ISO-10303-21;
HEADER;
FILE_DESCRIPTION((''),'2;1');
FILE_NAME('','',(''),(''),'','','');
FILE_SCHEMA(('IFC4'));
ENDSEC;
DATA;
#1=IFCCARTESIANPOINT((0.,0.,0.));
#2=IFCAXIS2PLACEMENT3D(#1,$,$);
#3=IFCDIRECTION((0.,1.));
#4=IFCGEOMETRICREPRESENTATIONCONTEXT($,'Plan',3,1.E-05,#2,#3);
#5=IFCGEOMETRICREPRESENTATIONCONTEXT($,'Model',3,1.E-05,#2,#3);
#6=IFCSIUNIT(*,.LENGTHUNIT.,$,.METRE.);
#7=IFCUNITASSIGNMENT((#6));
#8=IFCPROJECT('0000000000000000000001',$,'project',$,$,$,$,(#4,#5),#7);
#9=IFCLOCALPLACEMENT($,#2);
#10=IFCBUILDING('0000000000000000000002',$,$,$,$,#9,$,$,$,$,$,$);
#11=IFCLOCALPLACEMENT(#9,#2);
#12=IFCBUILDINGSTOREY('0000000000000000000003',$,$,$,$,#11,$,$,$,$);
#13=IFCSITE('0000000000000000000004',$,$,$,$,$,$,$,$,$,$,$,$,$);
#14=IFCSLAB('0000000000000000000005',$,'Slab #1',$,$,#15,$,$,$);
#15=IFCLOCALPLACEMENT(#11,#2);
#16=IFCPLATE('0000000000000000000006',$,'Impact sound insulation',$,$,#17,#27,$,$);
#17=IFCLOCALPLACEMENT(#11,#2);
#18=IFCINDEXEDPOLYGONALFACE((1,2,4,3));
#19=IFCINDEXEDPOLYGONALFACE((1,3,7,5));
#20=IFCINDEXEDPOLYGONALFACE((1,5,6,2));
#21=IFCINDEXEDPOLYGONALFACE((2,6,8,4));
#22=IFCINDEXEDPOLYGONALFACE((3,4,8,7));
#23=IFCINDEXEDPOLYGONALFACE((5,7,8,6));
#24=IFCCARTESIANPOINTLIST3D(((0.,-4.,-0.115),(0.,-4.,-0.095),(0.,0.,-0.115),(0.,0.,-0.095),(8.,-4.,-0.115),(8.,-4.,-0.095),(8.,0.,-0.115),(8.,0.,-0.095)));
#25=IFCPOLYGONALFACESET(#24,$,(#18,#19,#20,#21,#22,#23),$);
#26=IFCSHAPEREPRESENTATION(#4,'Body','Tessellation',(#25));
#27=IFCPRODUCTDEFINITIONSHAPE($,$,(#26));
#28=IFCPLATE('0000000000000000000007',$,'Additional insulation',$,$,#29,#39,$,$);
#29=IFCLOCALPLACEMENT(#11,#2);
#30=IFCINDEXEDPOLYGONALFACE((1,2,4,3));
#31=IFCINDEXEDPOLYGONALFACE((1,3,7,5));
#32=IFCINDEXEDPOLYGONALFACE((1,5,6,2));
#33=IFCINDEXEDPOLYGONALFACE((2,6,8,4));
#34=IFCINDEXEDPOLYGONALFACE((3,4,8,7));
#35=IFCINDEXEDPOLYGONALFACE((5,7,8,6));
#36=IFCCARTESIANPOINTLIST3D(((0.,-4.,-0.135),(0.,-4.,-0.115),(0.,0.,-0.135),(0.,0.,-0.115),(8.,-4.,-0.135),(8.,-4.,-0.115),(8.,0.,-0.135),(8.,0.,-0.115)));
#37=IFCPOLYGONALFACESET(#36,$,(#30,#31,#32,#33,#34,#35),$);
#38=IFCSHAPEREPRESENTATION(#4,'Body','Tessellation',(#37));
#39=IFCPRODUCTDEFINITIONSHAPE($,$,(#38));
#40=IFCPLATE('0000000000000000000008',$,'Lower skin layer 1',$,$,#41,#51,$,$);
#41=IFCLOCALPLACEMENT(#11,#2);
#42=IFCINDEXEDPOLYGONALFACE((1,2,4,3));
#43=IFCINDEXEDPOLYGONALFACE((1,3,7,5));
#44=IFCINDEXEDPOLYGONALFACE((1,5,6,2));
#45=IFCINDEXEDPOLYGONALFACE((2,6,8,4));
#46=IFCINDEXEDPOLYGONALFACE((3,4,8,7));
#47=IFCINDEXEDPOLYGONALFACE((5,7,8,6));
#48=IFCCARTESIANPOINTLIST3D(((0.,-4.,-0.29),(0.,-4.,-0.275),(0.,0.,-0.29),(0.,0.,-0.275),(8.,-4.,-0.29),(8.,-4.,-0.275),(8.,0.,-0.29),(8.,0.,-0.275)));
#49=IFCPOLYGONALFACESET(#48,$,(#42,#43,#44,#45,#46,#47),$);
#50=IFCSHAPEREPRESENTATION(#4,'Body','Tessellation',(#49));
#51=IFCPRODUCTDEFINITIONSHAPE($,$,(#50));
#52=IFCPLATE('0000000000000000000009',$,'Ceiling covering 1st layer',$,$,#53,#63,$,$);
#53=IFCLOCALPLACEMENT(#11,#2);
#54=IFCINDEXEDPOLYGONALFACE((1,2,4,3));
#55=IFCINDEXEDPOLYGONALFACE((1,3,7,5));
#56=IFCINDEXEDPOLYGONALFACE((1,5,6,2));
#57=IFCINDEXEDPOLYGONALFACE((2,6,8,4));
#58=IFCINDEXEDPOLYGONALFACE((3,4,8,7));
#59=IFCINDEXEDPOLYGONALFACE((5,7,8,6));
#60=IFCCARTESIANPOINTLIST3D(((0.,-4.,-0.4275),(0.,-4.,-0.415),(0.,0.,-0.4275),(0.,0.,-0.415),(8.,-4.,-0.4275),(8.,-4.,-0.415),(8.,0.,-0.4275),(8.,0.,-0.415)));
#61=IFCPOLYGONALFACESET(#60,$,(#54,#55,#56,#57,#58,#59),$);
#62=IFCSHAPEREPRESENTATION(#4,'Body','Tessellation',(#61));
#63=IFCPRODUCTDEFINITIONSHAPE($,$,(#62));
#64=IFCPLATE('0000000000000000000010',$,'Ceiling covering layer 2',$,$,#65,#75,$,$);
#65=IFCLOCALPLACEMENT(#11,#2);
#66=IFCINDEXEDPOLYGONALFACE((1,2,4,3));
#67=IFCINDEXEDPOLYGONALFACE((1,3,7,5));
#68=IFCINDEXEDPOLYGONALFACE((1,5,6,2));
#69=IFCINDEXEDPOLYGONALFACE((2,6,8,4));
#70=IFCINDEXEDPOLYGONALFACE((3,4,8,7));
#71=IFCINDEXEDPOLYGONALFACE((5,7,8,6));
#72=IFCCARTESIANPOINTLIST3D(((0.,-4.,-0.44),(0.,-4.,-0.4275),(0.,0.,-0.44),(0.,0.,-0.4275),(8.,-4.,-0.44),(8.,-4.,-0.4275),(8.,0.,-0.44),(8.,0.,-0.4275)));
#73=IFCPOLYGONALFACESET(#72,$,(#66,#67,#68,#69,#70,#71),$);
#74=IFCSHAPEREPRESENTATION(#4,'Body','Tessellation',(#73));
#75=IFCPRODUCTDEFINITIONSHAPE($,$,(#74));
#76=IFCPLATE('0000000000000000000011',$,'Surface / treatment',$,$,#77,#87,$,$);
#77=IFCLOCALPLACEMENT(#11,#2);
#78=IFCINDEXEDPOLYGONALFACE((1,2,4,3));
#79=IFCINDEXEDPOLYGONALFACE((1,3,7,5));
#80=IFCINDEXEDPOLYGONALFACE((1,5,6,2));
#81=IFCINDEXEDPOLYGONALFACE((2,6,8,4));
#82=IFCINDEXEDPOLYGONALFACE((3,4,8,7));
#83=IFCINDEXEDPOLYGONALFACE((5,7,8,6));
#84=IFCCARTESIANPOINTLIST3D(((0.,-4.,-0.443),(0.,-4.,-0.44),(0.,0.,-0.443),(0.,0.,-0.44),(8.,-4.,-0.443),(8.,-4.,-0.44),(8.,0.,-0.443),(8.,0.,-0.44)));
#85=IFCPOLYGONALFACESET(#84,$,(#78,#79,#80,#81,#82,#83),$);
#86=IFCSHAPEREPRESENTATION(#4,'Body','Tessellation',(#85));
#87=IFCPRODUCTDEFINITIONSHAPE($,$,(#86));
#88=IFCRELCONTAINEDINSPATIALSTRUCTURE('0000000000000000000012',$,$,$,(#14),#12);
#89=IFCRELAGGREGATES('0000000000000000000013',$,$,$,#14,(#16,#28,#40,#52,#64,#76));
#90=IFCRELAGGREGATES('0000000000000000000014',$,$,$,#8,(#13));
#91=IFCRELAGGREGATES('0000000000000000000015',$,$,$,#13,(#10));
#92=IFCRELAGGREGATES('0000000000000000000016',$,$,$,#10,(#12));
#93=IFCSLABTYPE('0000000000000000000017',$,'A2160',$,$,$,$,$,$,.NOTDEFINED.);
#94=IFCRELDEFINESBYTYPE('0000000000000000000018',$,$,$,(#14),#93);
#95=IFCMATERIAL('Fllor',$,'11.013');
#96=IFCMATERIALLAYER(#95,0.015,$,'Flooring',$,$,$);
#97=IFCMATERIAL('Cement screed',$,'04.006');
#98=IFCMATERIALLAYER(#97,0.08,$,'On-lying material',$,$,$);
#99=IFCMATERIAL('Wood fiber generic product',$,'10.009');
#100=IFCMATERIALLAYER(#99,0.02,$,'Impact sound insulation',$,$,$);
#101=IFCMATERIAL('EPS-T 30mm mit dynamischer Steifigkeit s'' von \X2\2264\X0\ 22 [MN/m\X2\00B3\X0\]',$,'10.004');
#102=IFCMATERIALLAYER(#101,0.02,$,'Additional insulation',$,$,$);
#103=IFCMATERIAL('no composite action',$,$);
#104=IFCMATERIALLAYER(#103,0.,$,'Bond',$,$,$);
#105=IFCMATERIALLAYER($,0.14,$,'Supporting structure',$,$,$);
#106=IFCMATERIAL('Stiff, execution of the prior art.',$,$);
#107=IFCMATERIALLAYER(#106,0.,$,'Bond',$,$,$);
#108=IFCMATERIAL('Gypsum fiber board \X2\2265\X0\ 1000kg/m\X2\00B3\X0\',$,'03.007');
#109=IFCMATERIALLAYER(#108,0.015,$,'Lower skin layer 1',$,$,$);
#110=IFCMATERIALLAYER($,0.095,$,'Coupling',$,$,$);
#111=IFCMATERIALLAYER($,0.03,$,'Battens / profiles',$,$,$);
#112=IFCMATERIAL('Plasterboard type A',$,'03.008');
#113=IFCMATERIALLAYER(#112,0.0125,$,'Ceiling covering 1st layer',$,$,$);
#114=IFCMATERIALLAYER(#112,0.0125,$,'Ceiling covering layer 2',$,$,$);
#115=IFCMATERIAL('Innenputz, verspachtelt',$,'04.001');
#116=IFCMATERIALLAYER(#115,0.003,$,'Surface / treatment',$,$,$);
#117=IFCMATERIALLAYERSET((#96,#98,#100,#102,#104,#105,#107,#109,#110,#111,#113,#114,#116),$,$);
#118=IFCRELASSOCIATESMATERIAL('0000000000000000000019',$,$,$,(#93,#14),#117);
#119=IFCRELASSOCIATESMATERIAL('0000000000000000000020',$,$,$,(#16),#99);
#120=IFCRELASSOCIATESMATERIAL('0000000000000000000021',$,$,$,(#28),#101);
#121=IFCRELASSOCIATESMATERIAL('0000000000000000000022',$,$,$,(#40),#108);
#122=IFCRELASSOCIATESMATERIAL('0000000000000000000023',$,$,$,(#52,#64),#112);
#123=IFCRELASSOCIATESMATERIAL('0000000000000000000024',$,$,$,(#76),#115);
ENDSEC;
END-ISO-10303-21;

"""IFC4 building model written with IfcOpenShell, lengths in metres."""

from ifc_helpers import new_model, si_unit, direction, frame, frame_2d, origin, place, context, project, spatial, rectangle, extrude, material, layer, layer_set, type_object, element, aggregate, save


model = new_model("IFC4")

# Units and contexts
plan_context = context("Plan", 3, precision=1e-05, world=origin(), true_north=direction((0.0, 1.0)))
model_context = context("Model", 3, precision=1e-05, world=origin(), true_north=direction((0.0, 1.0)))
ifc_project = project(units=[si_unit("LENGTHUNIT", "METRE")], contexts=[plan_context, model_context])

# Site, building, storey
site = spatial("IfcSite", under=ifc_project)
building_placement = place(None, origin())
building = spatial("IfcBuilding", under=site, at=building_placement)
storey_placement = place(building_placement, origin())
storey = spatial("IfcBuildingStorey", under=building, at=storey_placement)

# Slab, plates
ifc_material_1 = material(Name="Fllor", Category="11.013")
ifc_layer_1 = layer(ifc_material_1, 0.015, Name="Flooring")
ifc_material_2 = material(Name="Cement screed", Category="04.006")
ifc_layer_2 = layer(ifc_material_2, 0.08, Name="On-lying material")
ifc_material_3 = material(Name="Wood fiber generic product", Category="10.009")
ifc_layer_3 = layer(ifc_material_3, 0.02, Name="Impact sound insulation")
ifc_material_4 = material(Name="EPS-T 30mm mit dynamischer Steifigkeit s' von ≤ 22 [MN/m³]", Category="10.004")
ifc_layer_4 = layer(ifc_material_4, 0.02, Name="Additional insulation")
ifc_material_5 = material(Name="no composite action")
ifc_layer_5 = layer(ifc_material_5, 0.0, Name="Bond")
ifc_layer_6 = layer(None, 0.14, Name="Supporting structure")
ifc_material_6 = material(Name="Stiff, execution of the prior art.")
ifc_layer_7 = layer(ifc_material_6, 0.0, Name="Bond")
ifc_material_7 = material(Name="Gypsum fiber board ≥ 1000kg/m³", Category="03.007")
ifc_layer_8 = layer(ifc_material_7, 0.015, Name="Lower skin layer 1")
ifc_layer_9 = layer(None, 0.095, Name="Coupling")
ifc_layer_10 = layer(None, 0.03, Name="Battens / profiles")
ifc_material_8 = material(Name="Plasterboard type A", Category="03.008")
ifc_layer_11 = layer(ifc_material_8, 0.0125, Name="Ceiling covering 1st layer")
ifc_layer_12 = layer(ifc_material_8, 0.0125, Name="Ceiling covering layer 2")
ifc_material_9 = material(Name="Innenputz, verspachtelt", Category="04.001")
ifc_layer_13 = layer(ifc_material_9, 0.003, Name="Surface / treatment")
ifc_layer_set = layer_set([ifc_layer_1, ifc_layer_2, ifc_layer_3, ifc_layer_4, ifc_layer_5, ifc_layer_6, ifc_layer_7, ifc_layer_8, ifc_layer_9, ifc_layer_10, ifc_layer_11, ifc_layer_12, ifc_layer_13])
slab_type = type_object("IfcSlabType", Name="A2160", PredefinedType="NOTDEFINED", material=ifc_layer_set)
slab_placement = place(None, frame((0.0, 0.0, 0.0), z_axis=(0.0, 0.0, -1.0), x_axis=(1.0, 0.0, 0.0)))
slab = element("IfcSlab", 1, at=slab_placement, inside=storey, type_object=slab_type, material=ifc_layer_set, Name="Slab #1")
plate_1_placement = place(slab_placement, origin())
plate_1 = element("IfcPlate", 2, at=plate_1_placement, material=ifc_material_3, Name="Impact sound insulation", context=plan_context, shape_type="SweptSolid", body=[
    extrude(rectangle(XDim=8.0, YDim=4.0, at=frame_2d((4.0, 2.0), x_axis=(1.0, 0.0))), frame((0.0, 0.0, 0.095), z_axis=(0.0, 0.0, 1.0), x_axis=(1.0, 0.0, 0.0)), (0.0, 0.0, 1.0), 0.02),
])
plate_2_placement = place(slab_placement, origin())
plate_2 = element("IfcPlate", 3, at=plate_2_placement, material=ifc_material_4, Name="Additional insulation", context=plan_context, shape_type="SweptSolid", body=[
    extrude(rectangle(XDim=8.0, YDim=4.0, at=frame_2d((4.0, 2.0), x_axis=(1.0, 0.0))), frame((0.0, 0.0, 0.115), z_axis=(0.0, 0.0, 1.0), x_axis=(1.0, 0.0, 0.0)), (0.0, 0.0, 1.0), 0.02),
])
plate_3_placement = place(slab_placement, origin())
plate_3 = element("IfcPlate", 4, at=plate_3_placement, material=ifc_material_7, Name="Lower skin layer 1", context=plan_context, shape_type="SweptSolid", body=[
    extrude(rectangle(XDim=8.0, YDim=4.0, at=frame_2d((4.0, 2.0), x_axis=(1.0, 0.0))), frame((0.0, 0.0, 0.275), z_axis=(0.0, 0.0, 1.0), x_axis=(1.0, 0.0, 0.0)), (0.0, 0.0, 1.0), 0.015),
])
plate_4_placement = place(slab_placement, origin())
plate_4 = element("IfcPlate", 5, at=plate_4_placement, material=ifc_material_8, Name="Ceiling covering 1st layer", context=plan_context, shape_type="SweptSolid", body=[
    extrude(rectangle(XDim=8.0, YDim=4.0, at=frame_2d((4.0, 2.0), x_axis=(1.0, 0.0))), frame((0.0, 0.0, 0.415), z_axis=(0.0, 0.0, 1.0), x_axis=(1.0, 0.0, 0.0)), (0.0, 0.0, 1.0), 0.0125),
])
plate_5_placement = place(slab_placement, origin())
plate_5 = element("IfcPlate", 6, at=plate_5_placement, material=ifc_material_8, Name="Ceiling covering layer 2", context=plan_context, shape_type="SweptSolid", body=[
    extrude(rectangle(XDim=8.0, YDim=4.0, at=frame_2d((4.0, 2.0), x_axis=(1.0, 0.0))), frame((0.0, 0.0, 0.4275), z_axis=(0.0, 0.0, 1.0), x_axis=(1.0, 0.0, 0.0)), (0.0, 0.0, 1.0), 0.0125),
])
plate_6_placement = place(slab_placement, origin())
plate_6 = element("IfcPlate", 7, at=plate_6_placement, material=ifc_material_9, Name="Surface / treatment", context=plan_context, shape_type="SweptSolid", body=[
    extrude(rectangle(XDim=8.0, YDim=4.0, at=frame_2d((4.0, 2.0), x_axis=(1.0, 0.0))), frame((0.0, 0.0, 0.44), z_axis=(0.0, 0.0, 1.0), x_axis=(1.0, 0.0, 0.0)), (0.0, 0.0, 1.0), 0.003),
])
aggregate(slab, [plate_1, plate_2, plate_3, plate_4, plate_5, plate_6])

save(model, "model.ifc")
